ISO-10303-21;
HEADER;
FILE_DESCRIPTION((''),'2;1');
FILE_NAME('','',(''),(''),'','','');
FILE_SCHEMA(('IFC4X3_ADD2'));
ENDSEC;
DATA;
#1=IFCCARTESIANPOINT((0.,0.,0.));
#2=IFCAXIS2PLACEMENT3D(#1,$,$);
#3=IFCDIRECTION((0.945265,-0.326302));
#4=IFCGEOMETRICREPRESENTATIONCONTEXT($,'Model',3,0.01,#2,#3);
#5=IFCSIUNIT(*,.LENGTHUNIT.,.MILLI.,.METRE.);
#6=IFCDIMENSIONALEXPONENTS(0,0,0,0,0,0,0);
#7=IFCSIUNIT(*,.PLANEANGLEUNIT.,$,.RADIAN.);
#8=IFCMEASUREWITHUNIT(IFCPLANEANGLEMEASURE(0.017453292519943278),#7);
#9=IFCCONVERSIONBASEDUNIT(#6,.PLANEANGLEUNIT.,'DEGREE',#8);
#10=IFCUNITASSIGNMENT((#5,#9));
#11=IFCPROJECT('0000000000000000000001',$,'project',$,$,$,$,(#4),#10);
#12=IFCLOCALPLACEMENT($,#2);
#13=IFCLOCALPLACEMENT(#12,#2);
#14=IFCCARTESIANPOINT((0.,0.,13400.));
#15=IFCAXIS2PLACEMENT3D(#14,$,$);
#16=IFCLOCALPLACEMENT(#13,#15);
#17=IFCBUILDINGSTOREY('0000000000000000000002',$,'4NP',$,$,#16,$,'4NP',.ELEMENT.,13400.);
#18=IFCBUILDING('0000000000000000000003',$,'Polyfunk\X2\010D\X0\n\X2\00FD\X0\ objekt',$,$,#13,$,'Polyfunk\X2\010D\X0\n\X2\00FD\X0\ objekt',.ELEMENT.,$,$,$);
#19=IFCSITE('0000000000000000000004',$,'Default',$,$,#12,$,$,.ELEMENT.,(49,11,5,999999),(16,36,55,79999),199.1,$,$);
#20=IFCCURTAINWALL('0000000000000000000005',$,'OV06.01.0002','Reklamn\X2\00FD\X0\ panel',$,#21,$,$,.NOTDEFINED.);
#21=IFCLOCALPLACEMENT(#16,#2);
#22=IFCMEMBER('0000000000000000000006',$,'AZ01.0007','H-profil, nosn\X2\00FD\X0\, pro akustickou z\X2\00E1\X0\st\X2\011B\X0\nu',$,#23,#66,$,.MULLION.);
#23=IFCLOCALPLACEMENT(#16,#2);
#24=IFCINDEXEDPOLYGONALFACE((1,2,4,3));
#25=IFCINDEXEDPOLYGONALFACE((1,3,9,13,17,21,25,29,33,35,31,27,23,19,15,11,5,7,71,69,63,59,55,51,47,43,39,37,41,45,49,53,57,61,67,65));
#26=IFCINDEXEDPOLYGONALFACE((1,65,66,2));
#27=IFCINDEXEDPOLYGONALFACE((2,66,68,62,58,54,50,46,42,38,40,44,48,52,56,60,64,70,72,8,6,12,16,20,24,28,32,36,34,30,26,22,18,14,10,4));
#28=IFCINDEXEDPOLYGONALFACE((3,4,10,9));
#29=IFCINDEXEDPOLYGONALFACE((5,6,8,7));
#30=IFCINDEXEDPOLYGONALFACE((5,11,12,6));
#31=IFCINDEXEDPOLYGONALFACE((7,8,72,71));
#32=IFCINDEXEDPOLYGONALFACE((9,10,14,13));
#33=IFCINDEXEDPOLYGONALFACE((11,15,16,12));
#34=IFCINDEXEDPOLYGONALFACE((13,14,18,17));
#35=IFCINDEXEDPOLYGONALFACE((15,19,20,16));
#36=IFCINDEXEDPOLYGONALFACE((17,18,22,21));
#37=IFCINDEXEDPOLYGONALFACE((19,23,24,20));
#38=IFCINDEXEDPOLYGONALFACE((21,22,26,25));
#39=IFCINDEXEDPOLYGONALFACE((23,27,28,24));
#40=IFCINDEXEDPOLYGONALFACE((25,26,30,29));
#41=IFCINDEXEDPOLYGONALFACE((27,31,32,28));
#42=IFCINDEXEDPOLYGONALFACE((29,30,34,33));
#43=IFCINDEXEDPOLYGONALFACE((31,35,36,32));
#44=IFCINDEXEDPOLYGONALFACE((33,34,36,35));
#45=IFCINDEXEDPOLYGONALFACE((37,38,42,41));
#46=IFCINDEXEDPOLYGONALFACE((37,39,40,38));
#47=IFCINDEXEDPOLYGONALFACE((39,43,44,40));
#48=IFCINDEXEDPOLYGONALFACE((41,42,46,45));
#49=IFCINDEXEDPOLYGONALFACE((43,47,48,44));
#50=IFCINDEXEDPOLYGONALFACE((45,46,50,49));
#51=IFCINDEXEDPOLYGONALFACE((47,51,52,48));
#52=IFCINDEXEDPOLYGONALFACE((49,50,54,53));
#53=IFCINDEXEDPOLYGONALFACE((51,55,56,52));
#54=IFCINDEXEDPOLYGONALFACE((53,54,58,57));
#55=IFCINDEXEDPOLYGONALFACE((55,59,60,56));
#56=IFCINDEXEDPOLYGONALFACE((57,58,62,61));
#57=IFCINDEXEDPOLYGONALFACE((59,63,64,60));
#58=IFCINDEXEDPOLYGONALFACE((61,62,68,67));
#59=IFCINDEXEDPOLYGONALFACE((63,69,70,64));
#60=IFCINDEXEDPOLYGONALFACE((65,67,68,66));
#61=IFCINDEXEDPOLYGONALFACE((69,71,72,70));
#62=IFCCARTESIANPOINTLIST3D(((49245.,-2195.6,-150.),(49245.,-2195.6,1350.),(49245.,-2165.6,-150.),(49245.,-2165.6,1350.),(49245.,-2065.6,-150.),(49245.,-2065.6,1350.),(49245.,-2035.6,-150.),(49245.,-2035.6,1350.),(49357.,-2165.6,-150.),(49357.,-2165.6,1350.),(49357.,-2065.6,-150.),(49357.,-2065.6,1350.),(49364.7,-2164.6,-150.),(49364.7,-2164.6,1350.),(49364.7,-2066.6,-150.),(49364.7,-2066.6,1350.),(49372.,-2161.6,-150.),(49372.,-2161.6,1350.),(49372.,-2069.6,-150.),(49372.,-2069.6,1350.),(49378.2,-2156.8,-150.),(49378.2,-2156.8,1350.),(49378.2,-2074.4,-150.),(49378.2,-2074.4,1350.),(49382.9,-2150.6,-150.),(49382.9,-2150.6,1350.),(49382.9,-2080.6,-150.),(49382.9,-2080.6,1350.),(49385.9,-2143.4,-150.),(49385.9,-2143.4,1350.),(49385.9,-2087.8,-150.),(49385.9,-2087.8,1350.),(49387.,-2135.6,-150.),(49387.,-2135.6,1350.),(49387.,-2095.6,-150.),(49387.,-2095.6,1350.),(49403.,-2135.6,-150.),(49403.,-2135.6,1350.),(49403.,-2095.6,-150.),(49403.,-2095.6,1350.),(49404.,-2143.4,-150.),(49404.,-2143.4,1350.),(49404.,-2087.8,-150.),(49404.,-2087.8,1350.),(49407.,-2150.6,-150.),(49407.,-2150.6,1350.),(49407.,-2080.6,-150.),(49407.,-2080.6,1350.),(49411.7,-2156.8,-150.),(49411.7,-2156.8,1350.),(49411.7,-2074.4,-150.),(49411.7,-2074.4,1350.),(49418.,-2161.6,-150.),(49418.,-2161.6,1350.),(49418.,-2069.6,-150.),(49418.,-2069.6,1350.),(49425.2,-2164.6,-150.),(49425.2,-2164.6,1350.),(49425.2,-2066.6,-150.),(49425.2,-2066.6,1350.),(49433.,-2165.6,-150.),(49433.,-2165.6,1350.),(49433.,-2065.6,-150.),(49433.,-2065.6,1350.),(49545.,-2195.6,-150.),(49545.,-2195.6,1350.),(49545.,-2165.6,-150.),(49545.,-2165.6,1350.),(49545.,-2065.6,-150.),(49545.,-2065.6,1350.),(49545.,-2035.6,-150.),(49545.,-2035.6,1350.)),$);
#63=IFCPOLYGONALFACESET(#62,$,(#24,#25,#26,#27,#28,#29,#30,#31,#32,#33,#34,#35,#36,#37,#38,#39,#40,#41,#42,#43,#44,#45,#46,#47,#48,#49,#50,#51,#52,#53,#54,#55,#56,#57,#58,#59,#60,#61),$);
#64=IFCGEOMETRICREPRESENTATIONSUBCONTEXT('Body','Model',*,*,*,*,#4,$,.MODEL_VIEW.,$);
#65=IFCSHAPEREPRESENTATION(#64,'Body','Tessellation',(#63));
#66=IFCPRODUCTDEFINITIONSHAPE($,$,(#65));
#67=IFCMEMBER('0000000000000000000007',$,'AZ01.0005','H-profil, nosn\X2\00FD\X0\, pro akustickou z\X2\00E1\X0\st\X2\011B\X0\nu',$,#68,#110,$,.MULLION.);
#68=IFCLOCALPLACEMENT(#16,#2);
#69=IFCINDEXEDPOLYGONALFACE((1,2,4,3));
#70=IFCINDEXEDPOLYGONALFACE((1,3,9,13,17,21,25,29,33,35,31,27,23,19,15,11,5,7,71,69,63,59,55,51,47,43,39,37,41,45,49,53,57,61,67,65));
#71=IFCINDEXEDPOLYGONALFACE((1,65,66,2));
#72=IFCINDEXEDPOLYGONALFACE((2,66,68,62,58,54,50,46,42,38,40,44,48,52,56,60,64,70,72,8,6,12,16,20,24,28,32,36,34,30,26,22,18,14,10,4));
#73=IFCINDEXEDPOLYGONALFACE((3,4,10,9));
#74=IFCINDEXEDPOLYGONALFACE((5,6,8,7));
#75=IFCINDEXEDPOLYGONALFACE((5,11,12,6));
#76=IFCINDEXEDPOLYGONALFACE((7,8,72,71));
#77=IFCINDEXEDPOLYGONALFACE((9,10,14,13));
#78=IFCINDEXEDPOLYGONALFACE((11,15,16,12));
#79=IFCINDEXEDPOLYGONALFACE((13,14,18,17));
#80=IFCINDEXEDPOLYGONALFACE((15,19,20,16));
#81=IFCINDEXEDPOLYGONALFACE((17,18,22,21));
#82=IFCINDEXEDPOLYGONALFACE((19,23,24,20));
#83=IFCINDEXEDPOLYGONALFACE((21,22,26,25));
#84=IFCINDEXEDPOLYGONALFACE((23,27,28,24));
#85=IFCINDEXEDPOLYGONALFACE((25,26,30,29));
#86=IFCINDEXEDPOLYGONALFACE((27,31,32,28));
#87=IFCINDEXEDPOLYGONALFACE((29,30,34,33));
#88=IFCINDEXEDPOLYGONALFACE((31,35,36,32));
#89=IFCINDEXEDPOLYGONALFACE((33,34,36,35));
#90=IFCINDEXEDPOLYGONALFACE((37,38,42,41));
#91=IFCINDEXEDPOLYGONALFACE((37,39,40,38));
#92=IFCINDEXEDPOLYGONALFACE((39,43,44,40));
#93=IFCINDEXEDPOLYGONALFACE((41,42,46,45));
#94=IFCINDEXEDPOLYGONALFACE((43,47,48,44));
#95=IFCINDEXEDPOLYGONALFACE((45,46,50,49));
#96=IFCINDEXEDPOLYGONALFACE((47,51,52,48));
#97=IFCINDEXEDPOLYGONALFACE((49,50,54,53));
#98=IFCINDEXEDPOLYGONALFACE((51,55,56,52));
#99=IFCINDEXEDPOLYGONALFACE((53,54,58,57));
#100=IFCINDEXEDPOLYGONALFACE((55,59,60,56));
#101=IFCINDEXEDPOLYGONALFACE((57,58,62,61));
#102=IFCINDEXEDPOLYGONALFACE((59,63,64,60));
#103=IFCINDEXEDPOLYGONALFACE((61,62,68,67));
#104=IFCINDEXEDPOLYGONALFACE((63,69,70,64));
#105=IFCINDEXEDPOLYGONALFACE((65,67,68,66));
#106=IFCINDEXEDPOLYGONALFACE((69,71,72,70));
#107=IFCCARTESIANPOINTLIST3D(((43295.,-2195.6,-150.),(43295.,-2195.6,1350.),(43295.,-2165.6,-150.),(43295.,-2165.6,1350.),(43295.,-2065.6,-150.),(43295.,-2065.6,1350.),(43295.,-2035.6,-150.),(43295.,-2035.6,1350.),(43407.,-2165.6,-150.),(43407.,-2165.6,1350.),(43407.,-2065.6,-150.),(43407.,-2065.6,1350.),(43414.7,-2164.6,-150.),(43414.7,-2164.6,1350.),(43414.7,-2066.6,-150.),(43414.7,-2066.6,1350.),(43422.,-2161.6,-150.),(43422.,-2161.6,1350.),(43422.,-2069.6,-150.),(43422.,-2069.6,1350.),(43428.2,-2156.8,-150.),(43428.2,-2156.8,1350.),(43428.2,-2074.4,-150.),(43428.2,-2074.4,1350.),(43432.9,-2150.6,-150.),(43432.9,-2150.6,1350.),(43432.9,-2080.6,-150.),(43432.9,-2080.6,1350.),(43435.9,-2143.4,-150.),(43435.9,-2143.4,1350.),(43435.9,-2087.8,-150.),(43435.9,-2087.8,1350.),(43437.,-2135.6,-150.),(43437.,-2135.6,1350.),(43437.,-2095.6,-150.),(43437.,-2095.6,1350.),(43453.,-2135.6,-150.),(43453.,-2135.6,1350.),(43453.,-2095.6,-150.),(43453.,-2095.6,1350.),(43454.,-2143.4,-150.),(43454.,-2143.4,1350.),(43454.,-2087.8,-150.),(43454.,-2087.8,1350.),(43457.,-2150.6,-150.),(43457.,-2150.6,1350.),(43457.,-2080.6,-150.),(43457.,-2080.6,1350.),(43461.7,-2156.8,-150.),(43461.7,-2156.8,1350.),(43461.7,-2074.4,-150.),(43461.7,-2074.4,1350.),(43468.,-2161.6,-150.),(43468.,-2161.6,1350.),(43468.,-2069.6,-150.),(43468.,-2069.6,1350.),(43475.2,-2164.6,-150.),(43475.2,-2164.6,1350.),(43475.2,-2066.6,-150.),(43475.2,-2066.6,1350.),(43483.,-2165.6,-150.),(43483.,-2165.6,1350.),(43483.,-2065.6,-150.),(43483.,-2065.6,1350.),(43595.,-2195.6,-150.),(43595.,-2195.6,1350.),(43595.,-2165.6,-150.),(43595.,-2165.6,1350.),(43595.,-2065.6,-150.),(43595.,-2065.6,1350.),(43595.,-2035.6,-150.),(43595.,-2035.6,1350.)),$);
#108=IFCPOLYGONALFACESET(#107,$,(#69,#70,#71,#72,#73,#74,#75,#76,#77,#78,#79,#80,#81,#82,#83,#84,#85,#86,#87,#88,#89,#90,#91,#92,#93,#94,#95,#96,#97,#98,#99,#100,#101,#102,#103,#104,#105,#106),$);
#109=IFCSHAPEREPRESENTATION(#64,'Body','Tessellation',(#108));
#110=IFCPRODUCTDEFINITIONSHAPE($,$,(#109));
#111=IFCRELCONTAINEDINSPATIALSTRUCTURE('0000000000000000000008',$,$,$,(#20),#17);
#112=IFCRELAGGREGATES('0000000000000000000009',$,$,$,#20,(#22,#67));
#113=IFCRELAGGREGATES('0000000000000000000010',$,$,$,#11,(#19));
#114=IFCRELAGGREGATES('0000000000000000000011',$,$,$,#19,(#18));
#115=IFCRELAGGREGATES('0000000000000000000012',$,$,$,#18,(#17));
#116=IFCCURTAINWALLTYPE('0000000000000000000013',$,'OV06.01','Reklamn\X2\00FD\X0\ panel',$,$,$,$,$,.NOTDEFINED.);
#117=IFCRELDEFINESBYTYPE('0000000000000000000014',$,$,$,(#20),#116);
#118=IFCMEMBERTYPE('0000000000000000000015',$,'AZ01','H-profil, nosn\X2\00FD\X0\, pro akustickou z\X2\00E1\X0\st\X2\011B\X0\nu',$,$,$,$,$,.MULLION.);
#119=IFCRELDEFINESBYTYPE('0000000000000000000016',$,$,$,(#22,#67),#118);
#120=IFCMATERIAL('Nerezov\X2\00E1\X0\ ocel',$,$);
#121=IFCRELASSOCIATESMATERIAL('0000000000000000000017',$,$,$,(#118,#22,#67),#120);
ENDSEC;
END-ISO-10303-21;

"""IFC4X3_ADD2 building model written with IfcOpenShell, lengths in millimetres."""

from ifc_helpers import new_model, entity, si_unit, converted_unit, direction, frame, frame_2d, origin, place, context, subcontext, project, spatial, polyline, circle_curve, parameter, trimmed, segment, composite_curve, outline, extrude, source, transform, mapped, material, material_profile, profile_set, profile_usage, type_object, element, aggregate, save


model = new_model("IFC4X3_ADD2")

# Units and contexts
model_context = context("Model", 3, precision=0.01, world=origin(), true_north=direction((0.945265, -0.326302)))
body_context = subcontext(model_context, "Body", "Model", "MODEL_VIEW")
ifc_project = project(units=[si_unit("LENGTHUNIT", "METRE", prefix="MILLI"), converted_unit("PLANEANGLEUNIT", "DEGREE", entity("IfcPlaneAngleMeasure", 0.017453292519943278), si_unit("PLANEANGLEUNIT", "RADIAN"), dimensions=[0, 0, 0, 0, 0, 0, 0])], contexts=[model_context])

# Site, building, storey
site_placement = place(None, origin())
site = spatial("IfcSite", under=ifc_project, at=site_placement, Name="Default", CompositionType="ELEMENT", RefLatitude=(49, 11, 5, 999999), RefLongitude=(16, 36, 55, 79999), RefElevation=199.1)
building_placement = place(site_placement, origin())
building = spatial("IfcBuilding", under=site, at=building_placement, Name="Polyfunkčný objekt", LongName="Polyfunkčný objekt", CompositionType="ELEMENT")
storey_placement = place(building_placement, frame((0.0, 0.0, 13400.0)))
storey = spatial("IfcBuildingStorey", under=building, at=storey_placement, Name="4NP", LongName="4NP", CompositionType="ELEMENT", Elevation=13400.0)

# Curtain wall
curtain_wall_type = type_object("IfcCurtainWallType", Name="OV06.01", Description="Reklamný panel", PredefinedType="NOTDEFINED")
curtain_wall_1_placement = place(storey_placement, frame((0.0, 0.0, -13400.0)))
curtain_wall_1 = element("IfcCurtainWall", 1, at=curtain_wall_1_placement, inside=storey, type_object=curtain_wall_type, Name="OV06.01.0002", Description="Reklamný panel", PredefinedType="NOTDEFINED")
ifc_material_1 = material(Name="Nerezová ocel")
ifc_material_profile = material_profile(ifc_material_1, outline(composite_curve([segment(polyline([(50.0, -150.0), (80.0, -150.0)]), True, "CONTINUOUS"), segment(polyline([(80.0, -150.0), (80.0, 150.0)]), True, "CONTINUOUS"), segment(polyline([(80.0, 150.0), (50.0, 150.0)]), True, "CONTINUOUS"), segment(polyline([(50.0, 150.0), (50.0, 38.0)]), True, "CONTINUOUS"), segment(trimmed(circle_curve(frame_2d((20.0, 38.0), x_axis=(0.0, 1.0)), 30.0), [parameter(180.0)], [parameter(270.0)], True, "PARAMETER"), False, "CONTINUOUS"), segment(polyline([(20.0, 8.0), (-20.0, 8.0)]), True, "CONTINUOUS"), segment(trimmed(circle_curve(frame_2d((-20.0, 38.0), x_axis=(0.0, 1.0)), 30.0), [parameter(90.0)], [parameter(180.0)], True, "PARAMETER"), False, "CONTINUOUS"), segment(polyline([(-50.0, 38.0), (-50.0, 150.0)]), True, "CONTINUOUS"), segment(polyline([(-50.0, 150.0), (-80.0, 150.0)]), True, "CONTINUOUS"), segment(polyline([(-80.0, 150.0), (-80.0, -150.0)]), True, "CONTINUOUS"), segment(polyline([(-80.0, -150.0), (-50.0, -150.0)]), True, "CONTINUOUS"), segment(polyline([(-50.0, -150.0), (-50.0, -38.0)]), True, "CONTINUOUS"), segment(trimmed(circle_curve(frame_2d((-20.0, -38.0), x_axis=(0.0, 1.0)), 30.0), [parameter(0.0)], [parameter(90.0)], True, "PARAMETER"), False, "CONTINUOUS"), segment(polyline([(-20.0, -8.0), (20.0, -8.0)]), True, "CONTINUOUS"), segment(trimmed(circle_curve(frame_2d((20.0, -38.0), x_axis=(0.0, 1.0)), 30.0), [parameter(270.0)], [parameter(0.0)], True, "PARAMETER"), False, "CONTINUOUS"), segment(polyline([(50.0, -38.0), (50.0, -150.0)]), True, "CONTINUOUS")], self_intersect=False)), Name="Profil zástena")
ifc_profile_set = profile_set([ifc_material_profile], Name="Profil zástena")
ifc_profile_usage = profile_usage(ifc_profile_set)
member_type_1 = type_object("IfcMemberType", Name="AZ01", Description="H-profil, nosný, pro akustickou zástěnu", PredefinedType="MULLION", material=ifc_profile_set)
shared_shape_1 = source(origin(), body_context, "Body", "SweptSolid", [
    extrude(outline(composite_curve([segment(polyline([(-150.0, -50.0), (-150.0, -80.0)]), True, "CONTINUOUS"), segment(polyline([(-150.0, -80.0), (150.0, -80.0)]), True, "CONTINUOUS"), segment(polyline([(150.0, -80.0), (150.0, -50.0)]), True, "CONTINUOUS"), segment(polyline([(150.0, -50.0), (38.0, -50.0)]), True, "CONTINUOUS"), segment(trimmed(circle_curve(frame_2d((38.0, -20.0), x_axis=(1.0, 0.0)), 30.0), [parameter(180.0)], [parameter(270.0)], True, "PARAMETER"), False, "CONTINUOUS"), segment(polyline([(8.0, -20.0), (8.0, 20.0)]), True, "CONTINUOUS"), segment(trimmed(circle_curve(frame_2d((38.0, 20.0), x_axis=(1.0, 0.0)), 30.0), [parameter(90.0)], [parameter(180.0)], True, "PARAMETER"), False, "CONTINUOUS"), segment(polyline([(38.0, 50.0), (150.0, 50.0)]), True, "CONTINUOUS"), segment(polyline([(150.0, 50.0), (150.0, 80.0)]), True, "CONTINUOUS"), segment(polyline([(150.0, 80.0), (-150.0, 80.0)]), True, "CONTINUOUS"), segment(polyline([(-150.0, 80.0), (-150.0, 50.0)]), True, "CONTINUOUS"), segment(polyline([(-150.0, 50.0), (-38.0, 50.0)]), True, "CONTINUOUS"), segment(trimmed(circle_curve(frame_2d((-38.0, 20.0), x_axis=(1.0, 0.0)), 30.0), [parameter(0.0)], [parameter(90.0)], True, "PARAMETER"), False, "CONTINUOUS"), segment(polyline([(-8.0, 20.0), (-8.0, -20.0)]), True, "CONTINUOUS"), segment(trimmed(circle_curve(frame_2d((-38.0, -20.0), x_axis=(1.0, 0.0)), 30.0), [parameter(270.0)], [parameter(0.0)], True, "PARAMETER"), False, "CONTINUOUS"), segment(polyline([(-38.0, -50.0), (-150.0, -50.0)]), True, "CONTINUOUS")], self_intersect=False)), frame((-150.0, 0.0, -1500.0), z_axis=(0.0, 0.0, -1.0), x_axis=(1.0, 0.0, 0.0)), (0.0, 0.0, -1.0), 1500.0),
])

# Members
member_1_placement = place(curtain_wall_1_placement, frame((49545.0, -2115.6, 13250.0), z_axis=(0.0, 0.0, -1.0), x_axis=(1.0, 0.0, 0.0)))
member_1 = element("IfcMember", 2, at=member_1_placement, type_object=member_type_1, material=ifc_profile_usage, Name="AZ01.0007", Description="H-profil, nosný, pro akustickou zástěnu", PredefinedType="MULLION", context=body_context, shape_type="MappedRepresentation", body=[
    mapped(shared_shape_1, transform((0.0, 0.0, 0.0), scale=1.0)),
])
shared_shape_2 = source(origin(), body_context, "Body", "SweptSolid", [
    extrude(outline(composite_curve([segment(polyline([(50.0, -150.0), (80.0, -150.0)]), True, "CONTINUOUS"), segment(polyline([(80.0, -150.0), (80.0, 150.0)]), True, "CONTINUOUS"), segment(polyline([(80.0, 150.0), (50.0, 150.0)]), True, "CONTINUOUS"), segment(polyline([(50.0, 150.0), (50.0, 38.0)]), True, "CONTINUOUS"), segment(trimmed(circle_curve(frame_2d((20.0, 38.0), x_axis=(0.0, 1.0)), 30.0), [parameter(180.0)], [parameter(270.0)], True, "PARAMETER"), False, "CONTINUOUS"), segment(polyline([(20.0, 8.0), (-20.0, 8.0)]), True, "CONTINUOUS"), segment(trimmed(circle_curve(frame_2d((-20.0, 38.0), x_axis=(0.0, 1.0)), 30.0), [parameter(90.0)], [parameter(180.0)], True, "PARAMETER"), False, "CONTINUOUS"), segment(polyline([(-50.0, 38.0), (-50.0, 150.0)]), True, "CONTINUOUS"), segment(polyline([(-50.0, 150.0), (-80.0, 150.0)]), True, "CONTINUOUS"), segment(polyline([(-80.0, 150.0), (-80.0, -150.0)]), True, "CONTINUOUS"), segment(polyline([(-80.0, -150.0), (-50.0, -150.0)]), True, "CONTINUOUS"), segment(polyline([(-50.0, -150.0), (-50.0, -38.0)]), True, "CONTINUOUS"), segment(trimmed(circle_curve(frame_2d((-20.0, -38.0), x_axis=(0.0, 1.0)), 30.0), [parameter(0.0)], [parameter(90.0)], True, "PARAMETER"), False, "CONTINUOUS"), segment(polyline([(-20.0, -8.0), (20.0, -8.0)]), True, "CONTINUOUS"), segment(trimmed(circle_curve(frame_2d((20.0, -38.0), x_axis=(0.0, 1.0)), 30.0), [parameter(270.0)], [parameter(0.0)], True, "PARAMETER"), False, "CONTINUOUS"), segment(polyline([(50.0, -38.0), (50.0, -150.0)]), True, "CONTINUOUS")], self_intersect=False)), frame((-150.0, 0.0, -1500.0), z_axis=(0.0, 0.0, 1.0), x_axis=(0.0, 1.0, 0.0)), (0.0, 0.0, 1.0), 1500.0),
])
member_2_placement = place(curtain_wall_1_placement, frame((43295.0, -2115.6, 14750.0), z_axis=(0.0, 0.0, 1.0), x_axis=(-1.0, 0.0, 0.0)))
member_2 = element("IfcMember", 3, at=member_2_placement, type_object=member_type_1, material=ifc_profile_usage, Name="AZ01.0005", Description="H-profil, nosný, pro akustickou zástěnu", PredefinedType="MULLION", context=body_context, shape_type="MappedRepresentation", body=[
    mapped(shared_shape_2, transform((0.0, 0.0, 0.0), scale=1.0)),
])

aggregate(curtain_wall_1, [member_1, member_2])

save(model, "model.ifc")
